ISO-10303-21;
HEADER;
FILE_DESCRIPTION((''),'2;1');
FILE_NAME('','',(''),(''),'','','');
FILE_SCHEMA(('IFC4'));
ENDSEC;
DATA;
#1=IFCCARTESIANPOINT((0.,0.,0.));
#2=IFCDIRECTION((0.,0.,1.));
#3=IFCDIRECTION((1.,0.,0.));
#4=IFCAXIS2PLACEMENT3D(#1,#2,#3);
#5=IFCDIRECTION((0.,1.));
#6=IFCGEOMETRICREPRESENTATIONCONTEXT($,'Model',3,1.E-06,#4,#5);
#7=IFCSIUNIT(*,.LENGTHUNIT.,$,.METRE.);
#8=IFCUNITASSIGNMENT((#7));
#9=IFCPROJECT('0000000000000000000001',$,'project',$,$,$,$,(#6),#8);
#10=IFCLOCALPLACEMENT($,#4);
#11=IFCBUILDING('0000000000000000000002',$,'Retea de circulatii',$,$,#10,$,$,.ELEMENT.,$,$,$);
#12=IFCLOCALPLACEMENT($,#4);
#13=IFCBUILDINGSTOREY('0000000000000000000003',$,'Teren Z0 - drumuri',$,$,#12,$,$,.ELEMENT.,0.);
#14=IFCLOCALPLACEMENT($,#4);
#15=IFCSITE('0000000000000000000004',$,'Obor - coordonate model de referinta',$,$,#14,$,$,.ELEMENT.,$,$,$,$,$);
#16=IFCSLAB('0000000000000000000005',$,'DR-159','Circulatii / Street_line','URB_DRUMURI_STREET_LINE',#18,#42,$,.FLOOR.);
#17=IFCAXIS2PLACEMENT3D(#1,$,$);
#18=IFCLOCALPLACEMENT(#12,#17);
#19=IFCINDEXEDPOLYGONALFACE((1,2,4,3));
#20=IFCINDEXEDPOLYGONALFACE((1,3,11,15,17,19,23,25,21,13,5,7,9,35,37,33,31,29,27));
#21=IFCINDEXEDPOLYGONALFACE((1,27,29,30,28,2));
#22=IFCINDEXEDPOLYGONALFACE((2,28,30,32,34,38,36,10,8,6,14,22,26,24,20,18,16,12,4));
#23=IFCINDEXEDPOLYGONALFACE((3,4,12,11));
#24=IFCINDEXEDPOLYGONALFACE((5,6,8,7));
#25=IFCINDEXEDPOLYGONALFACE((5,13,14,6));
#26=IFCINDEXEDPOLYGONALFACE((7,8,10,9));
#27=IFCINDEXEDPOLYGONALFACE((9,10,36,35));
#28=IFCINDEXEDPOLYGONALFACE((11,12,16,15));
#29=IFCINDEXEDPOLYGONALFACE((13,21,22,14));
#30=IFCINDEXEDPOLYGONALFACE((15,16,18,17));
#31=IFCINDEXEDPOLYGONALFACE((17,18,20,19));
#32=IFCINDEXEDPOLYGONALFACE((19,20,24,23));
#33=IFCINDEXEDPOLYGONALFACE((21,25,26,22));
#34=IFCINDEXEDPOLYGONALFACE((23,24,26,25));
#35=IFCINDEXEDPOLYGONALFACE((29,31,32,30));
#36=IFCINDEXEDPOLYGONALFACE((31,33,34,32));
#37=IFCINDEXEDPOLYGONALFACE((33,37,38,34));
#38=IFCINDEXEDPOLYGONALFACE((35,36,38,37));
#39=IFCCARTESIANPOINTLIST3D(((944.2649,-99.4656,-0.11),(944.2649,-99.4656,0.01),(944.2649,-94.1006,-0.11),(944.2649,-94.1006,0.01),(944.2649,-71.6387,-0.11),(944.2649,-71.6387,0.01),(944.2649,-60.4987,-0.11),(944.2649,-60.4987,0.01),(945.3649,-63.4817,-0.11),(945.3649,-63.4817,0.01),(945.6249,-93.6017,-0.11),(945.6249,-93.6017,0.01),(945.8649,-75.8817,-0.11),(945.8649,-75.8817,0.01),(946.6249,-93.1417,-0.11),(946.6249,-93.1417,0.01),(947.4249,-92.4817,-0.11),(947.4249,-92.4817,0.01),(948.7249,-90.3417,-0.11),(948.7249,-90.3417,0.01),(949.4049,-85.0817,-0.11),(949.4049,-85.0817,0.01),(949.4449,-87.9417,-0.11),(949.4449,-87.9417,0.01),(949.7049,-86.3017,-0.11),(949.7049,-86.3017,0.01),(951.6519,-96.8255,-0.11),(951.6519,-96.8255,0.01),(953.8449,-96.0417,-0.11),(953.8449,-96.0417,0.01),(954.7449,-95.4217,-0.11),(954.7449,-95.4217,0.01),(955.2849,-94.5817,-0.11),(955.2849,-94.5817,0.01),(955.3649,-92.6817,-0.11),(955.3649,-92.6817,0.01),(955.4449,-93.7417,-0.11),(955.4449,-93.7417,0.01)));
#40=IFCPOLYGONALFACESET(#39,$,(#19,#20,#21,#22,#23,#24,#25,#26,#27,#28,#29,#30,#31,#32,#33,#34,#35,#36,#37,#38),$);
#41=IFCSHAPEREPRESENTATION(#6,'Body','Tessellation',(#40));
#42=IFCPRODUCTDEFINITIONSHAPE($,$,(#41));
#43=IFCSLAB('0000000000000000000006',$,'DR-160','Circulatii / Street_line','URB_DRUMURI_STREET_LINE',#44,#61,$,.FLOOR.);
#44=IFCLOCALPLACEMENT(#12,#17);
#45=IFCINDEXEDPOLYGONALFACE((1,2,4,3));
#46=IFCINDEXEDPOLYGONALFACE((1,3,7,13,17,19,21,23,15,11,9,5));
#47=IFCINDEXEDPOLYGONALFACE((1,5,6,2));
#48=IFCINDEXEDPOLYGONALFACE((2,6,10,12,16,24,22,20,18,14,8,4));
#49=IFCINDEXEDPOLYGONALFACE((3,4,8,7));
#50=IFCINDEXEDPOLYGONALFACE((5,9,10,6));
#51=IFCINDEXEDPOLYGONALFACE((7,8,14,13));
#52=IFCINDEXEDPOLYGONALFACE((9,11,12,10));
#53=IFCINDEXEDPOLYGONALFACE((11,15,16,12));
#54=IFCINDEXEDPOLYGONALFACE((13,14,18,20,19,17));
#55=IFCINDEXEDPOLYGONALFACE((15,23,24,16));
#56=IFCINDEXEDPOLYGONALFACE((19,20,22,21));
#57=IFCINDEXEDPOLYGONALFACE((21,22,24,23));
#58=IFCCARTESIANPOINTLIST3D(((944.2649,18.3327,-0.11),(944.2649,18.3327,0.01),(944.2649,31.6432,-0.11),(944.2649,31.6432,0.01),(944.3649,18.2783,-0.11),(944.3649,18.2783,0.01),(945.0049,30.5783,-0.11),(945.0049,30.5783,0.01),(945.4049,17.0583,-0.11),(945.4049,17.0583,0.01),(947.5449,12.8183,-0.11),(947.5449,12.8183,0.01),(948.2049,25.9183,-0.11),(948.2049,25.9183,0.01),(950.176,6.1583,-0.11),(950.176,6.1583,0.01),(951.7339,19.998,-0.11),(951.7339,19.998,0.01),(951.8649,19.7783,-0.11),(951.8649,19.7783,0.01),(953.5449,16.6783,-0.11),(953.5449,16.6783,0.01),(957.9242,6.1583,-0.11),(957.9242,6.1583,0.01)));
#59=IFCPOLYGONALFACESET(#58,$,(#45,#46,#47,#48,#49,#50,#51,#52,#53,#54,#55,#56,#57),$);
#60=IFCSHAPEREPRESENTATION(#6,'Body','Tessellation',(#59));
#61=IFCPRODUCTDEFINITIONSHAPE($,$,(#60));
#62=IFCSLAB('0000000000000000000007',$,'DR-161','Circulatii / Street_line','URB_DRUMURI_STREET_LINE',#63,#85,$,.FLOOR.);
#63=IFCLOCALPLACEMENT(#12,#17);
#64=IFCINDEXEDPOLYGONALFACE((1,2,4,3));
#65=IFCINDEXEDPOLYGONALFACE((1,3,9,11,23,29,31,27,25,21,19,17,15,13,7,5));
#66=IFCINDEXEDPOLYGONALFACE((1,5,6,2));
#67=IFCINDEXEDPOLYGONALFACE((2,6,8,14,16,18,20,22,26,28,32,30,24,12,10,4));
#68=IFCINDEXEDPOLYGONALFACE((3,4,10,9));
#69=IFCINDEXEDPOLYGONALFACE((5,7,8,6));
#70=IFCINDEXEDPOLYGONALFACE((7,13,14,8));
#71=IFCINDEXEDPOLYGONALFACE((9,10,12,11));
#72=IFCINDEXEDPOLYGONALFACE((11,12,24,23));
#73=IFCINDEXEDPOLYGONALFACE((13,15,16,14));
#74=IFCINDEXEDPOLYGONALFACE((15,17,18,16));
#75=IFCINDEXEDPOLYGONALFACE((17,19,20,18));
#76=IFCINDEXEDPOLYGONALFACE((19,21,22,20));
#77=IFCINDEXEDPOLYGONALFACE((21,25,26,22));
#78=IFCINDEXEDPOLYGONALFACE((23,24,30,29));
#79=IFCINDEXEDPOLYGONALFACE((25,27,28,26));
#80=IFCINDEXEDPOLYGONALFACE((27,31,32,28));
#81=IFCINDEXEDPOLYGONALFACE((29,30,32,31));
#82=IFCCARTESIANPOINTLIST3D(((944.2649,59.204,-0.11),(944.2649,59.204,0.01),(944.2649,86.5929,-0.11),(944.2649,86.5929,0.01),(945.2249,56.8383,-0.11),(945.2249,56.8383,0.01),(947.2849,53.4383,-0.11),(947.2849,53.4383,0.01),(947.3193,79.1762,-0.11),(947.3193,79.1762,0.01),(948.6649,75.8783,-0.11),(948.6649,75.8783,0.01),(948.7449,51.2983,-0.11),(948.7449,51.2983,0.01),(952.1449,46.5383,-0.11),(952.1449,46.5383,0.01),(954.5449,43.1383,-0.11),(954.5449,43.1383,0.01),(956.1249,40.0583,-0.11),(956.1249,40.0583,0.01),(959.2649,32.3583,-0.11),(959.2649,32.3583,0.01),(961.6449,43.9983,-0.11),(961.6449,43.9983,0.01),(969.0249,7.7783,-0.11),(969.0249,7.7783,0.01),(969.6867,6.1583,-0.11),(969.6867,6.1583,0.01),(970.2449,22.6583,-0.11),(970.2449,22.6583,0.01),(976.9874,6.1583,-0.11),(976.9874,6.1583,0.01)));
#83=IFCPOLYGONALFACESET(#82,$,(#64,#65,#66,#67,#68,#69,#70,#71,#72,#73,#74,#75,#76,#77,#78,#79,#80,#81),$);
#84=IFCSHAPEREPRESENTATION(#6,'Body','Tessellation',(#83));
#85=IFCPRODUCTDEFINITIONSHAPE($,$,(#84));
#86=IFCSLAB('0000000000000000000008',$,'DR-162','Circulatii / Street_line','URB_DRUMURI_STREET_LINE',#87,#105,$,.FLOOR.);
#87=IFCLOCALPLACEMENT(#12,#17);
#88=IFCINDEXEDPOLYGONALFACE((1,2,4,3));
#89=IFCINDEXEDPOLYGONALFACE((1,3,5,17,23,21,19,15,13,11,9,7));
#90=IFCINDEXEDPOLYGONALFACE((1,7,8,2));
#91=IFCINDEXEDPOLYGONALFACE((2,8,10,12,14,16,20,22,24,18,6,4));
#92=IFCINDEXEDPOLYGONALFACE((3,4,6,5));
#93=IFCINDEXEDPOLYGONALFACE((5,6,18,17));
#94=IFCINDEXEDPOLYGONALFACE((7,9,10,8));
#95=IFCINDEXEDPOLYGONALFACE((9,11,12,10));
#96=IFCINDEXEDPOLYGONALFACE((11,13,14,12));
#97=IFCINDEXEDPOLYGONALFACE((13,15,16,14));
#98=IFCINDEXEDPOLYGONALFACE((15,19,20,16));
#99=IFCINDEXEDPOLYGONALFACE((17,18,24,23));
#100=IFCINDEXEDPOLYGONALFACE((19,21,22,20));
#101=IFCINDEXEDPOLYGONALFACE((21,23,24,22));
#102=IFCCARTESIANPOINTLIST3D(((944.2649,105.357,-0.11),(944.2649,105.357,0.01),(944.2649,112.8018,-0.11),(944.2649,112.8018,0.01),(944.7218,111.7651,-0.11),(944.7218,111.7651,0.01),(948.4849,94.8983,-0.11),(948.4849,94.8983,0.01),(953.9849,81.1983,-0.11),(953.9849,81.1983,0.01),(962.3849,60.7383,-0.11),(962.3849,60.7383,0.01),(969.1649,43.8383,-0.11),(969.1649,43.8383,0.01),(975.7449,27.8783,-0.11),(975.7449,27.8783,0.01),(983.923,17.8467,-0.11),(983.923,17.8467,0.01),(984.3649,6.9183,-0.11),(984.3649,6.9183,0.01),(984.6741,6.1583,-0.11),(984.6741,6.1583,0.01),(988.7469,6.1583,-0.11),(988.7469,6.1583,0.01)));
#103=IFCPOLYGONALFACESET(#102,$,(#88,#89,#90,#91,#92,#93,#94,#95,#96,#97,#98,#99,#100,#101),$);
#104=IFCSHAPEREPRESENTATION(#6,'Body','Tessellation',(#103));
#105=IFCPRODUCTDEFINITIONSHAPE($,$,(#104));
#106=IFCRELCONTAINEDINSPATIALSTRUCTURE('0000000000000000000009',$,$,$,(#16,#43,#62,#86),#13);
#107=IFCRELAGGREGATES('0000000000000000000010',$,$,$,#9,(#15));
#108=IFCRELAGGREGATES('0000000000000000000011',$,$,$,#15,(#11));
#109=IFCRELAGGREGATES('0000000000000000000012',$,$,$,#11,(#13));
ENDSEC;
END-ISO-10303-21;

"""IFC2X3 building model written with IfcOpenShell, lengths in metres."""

from ifc_helpers import new_model, si_unit, direction, frame, origin_with_axes, place, context, project, spatial, polyline, outline, extrude, element, save


model = new_model("IFC2X3")

# Units and contexts
model_context = context("Model", 3, precision=1e-06, world=origin_with_axes(), true_north=direction((0.0, 1.0)))
ifc_project = project(units=[si_unit("LENGTHUNIT", "METRE")], contexts=[model_context])

# Site, building, storey
site_placement = place(None, origin_with_axes())
site = spatial("IfcSite", under=ifc_project, at=site_placement, Name="Obor - coordonate model de referinta", CompositionType="ELEMENT")
building_placement = place(None, origin_with_axes())
building = spatial("IfcBuilding", under=site, at=building_placement, Name="Retea de circulatii", CompositionType="ELEMENT")
storey_placement = place(None, origin_with_axes())
storey = spatial("IfcBuildingStorey", under=building, at=storey_placement, Name="Teren Z0 - drumuri", CompositionType="ELEMENT", Elevation=0.0)

# Slabs
slab_1_placement = place(None, origin_with_axes())
element("IfcSlab", 1, at=slab_1_placement, inside=storey, Name="DR-159", Description="Circulatii / Street_line", ObjectType="URB_DRUMURI_STREET_LINE", PredefinedType="FLOOR", context=model_context, shape_type="SweptSolid", body=[
    extrude(outline(polyline([(948.7249, -90.3417), (947.4249, -92.4817), (946.6249, -93.1417), (945.6249, -93.6017), (944.2649, -94.1006), (944.2649, -99.4656), (951.6519, -96.8255), (953.8449, -96.0417), (954.7449, -95.4217), (955.2849, -94.5817), (955.4449, -93.7417), (955.3649, -92.6817), (945.3649, -63.4817), (944.2649, -60.4987), (944.2649, -71.6387), (945.8649, -75.8817), (949.4049, -85.0817), (949.7049, -86.3017), (949.4449, -87.9417), (948.7249, -90.3417)])), frame((0.0, 0.0, -0.11), z_axis=(0.0, 0.0, 1.0), x_axis=(1.0, 0.0, 0.0)), (0.0, 0.0, 1.0), 0.12),
])
slab_2_placement = place(None, origin_with_axes())
element("IfcSlab", 2, at=slab_2_placement, inside=storey, Name="DR-160", Description="Circulatii / Street_line", ObjectType="URB_DRUMURI_STREET_LINE", PredefinedType="FLOOR", context=model_context, shape_type="SweptSolid", body=[
    extrude(outline(polyline([(945.4049, 17.0583), (947.5449, 12.8183), (950.176, 6.1583), (957.9242, 6.1583), (953.5449, 16.6783), (951.8649, 19.7783), (951.7339, 19.998), (948.2049, 25.9183), (945.0049, 30.5783), (944.2649, 31.6432), (944.2649, 18.3327), (944.3649, 18.2783), (945.4049, 17.0583)])), frame((0.0, 0.0, -0.11), z_axis=(0.0, 0.0, 1.0), x_axis=(1.0, 0.0, 0.0)), (0.0, 0.0, 1.0), 0.12),
])
slab_3_placement = place(None, origin_with_axes())
element("IfcSlab", 3, at=slab_3_placement, inside=storey, Name="DR-161", Description="Circulatii / Street_line", ObjectType="URB_DRUMURI_STREET_LINE", PredefinedType="FLOOR", context=model_context, shape_type="SweptSolid", body=[
    extrude(outline(polyline([(961.6449, 43.9983), (948.6649, 75.8783), (947.3193, 79.1762), (944.2649, 86.5929), (944.2649, 59.204), (945.2249, 56.8383), (947.2849, 53.4383), (948.7449, 51.2983), (952.1449, 46.5383), (954.5449, 43.1383), (956.1249, 40.0583), (959.2649, 32.3583), (969.0249, 7.7783), (969.6867, 6.1583), (976.9874, 6.1583), (970.2449, 22.6583), (961.6449, 43.9983)])), frame((0.0, 0.0, -0.11), z_axis=(0.0, 0.0, 1.0), x_axis=(1.0, 0.0, 0.0)), (0.0, 0.0, 1.0), 0.12),
])
slab_4_placement = place(None, origin_with_axes())
element("IfcSlab", 4, at=slab_4_placement, inside=storey, Name="DR-162", Description="Circulatii / Street_line", ObjectType="URB_DRUMURI_STREET_LINE", PredefinedType="FLOOR", context=model_context, shape_type="SweptSolid", body=[
    extrude(outline(polyline([(988.7469, 6.1583), (983.923, 17.8467), (944.7218, 111.7651), (944.2649, 112.8018), (944.2649, 105.357), (948.4849, 94.8983), (953.9849, 81.1983), (962.3849, 60.7383), (969.1649, 43.8383), (975.7449, 27.8783), (984.3649, 6.9183), (984.6741, 6.1583), (988.7469, 6.1583)])), frame((0.0, 0.0, -0.11), z_axis=(0.0, 0.0, 1.0), x_axis=(1.0, 0.0, 0.0)), (0.0, 0.0, 1.0), 0.12),
])

save(model, "model.ifc")
